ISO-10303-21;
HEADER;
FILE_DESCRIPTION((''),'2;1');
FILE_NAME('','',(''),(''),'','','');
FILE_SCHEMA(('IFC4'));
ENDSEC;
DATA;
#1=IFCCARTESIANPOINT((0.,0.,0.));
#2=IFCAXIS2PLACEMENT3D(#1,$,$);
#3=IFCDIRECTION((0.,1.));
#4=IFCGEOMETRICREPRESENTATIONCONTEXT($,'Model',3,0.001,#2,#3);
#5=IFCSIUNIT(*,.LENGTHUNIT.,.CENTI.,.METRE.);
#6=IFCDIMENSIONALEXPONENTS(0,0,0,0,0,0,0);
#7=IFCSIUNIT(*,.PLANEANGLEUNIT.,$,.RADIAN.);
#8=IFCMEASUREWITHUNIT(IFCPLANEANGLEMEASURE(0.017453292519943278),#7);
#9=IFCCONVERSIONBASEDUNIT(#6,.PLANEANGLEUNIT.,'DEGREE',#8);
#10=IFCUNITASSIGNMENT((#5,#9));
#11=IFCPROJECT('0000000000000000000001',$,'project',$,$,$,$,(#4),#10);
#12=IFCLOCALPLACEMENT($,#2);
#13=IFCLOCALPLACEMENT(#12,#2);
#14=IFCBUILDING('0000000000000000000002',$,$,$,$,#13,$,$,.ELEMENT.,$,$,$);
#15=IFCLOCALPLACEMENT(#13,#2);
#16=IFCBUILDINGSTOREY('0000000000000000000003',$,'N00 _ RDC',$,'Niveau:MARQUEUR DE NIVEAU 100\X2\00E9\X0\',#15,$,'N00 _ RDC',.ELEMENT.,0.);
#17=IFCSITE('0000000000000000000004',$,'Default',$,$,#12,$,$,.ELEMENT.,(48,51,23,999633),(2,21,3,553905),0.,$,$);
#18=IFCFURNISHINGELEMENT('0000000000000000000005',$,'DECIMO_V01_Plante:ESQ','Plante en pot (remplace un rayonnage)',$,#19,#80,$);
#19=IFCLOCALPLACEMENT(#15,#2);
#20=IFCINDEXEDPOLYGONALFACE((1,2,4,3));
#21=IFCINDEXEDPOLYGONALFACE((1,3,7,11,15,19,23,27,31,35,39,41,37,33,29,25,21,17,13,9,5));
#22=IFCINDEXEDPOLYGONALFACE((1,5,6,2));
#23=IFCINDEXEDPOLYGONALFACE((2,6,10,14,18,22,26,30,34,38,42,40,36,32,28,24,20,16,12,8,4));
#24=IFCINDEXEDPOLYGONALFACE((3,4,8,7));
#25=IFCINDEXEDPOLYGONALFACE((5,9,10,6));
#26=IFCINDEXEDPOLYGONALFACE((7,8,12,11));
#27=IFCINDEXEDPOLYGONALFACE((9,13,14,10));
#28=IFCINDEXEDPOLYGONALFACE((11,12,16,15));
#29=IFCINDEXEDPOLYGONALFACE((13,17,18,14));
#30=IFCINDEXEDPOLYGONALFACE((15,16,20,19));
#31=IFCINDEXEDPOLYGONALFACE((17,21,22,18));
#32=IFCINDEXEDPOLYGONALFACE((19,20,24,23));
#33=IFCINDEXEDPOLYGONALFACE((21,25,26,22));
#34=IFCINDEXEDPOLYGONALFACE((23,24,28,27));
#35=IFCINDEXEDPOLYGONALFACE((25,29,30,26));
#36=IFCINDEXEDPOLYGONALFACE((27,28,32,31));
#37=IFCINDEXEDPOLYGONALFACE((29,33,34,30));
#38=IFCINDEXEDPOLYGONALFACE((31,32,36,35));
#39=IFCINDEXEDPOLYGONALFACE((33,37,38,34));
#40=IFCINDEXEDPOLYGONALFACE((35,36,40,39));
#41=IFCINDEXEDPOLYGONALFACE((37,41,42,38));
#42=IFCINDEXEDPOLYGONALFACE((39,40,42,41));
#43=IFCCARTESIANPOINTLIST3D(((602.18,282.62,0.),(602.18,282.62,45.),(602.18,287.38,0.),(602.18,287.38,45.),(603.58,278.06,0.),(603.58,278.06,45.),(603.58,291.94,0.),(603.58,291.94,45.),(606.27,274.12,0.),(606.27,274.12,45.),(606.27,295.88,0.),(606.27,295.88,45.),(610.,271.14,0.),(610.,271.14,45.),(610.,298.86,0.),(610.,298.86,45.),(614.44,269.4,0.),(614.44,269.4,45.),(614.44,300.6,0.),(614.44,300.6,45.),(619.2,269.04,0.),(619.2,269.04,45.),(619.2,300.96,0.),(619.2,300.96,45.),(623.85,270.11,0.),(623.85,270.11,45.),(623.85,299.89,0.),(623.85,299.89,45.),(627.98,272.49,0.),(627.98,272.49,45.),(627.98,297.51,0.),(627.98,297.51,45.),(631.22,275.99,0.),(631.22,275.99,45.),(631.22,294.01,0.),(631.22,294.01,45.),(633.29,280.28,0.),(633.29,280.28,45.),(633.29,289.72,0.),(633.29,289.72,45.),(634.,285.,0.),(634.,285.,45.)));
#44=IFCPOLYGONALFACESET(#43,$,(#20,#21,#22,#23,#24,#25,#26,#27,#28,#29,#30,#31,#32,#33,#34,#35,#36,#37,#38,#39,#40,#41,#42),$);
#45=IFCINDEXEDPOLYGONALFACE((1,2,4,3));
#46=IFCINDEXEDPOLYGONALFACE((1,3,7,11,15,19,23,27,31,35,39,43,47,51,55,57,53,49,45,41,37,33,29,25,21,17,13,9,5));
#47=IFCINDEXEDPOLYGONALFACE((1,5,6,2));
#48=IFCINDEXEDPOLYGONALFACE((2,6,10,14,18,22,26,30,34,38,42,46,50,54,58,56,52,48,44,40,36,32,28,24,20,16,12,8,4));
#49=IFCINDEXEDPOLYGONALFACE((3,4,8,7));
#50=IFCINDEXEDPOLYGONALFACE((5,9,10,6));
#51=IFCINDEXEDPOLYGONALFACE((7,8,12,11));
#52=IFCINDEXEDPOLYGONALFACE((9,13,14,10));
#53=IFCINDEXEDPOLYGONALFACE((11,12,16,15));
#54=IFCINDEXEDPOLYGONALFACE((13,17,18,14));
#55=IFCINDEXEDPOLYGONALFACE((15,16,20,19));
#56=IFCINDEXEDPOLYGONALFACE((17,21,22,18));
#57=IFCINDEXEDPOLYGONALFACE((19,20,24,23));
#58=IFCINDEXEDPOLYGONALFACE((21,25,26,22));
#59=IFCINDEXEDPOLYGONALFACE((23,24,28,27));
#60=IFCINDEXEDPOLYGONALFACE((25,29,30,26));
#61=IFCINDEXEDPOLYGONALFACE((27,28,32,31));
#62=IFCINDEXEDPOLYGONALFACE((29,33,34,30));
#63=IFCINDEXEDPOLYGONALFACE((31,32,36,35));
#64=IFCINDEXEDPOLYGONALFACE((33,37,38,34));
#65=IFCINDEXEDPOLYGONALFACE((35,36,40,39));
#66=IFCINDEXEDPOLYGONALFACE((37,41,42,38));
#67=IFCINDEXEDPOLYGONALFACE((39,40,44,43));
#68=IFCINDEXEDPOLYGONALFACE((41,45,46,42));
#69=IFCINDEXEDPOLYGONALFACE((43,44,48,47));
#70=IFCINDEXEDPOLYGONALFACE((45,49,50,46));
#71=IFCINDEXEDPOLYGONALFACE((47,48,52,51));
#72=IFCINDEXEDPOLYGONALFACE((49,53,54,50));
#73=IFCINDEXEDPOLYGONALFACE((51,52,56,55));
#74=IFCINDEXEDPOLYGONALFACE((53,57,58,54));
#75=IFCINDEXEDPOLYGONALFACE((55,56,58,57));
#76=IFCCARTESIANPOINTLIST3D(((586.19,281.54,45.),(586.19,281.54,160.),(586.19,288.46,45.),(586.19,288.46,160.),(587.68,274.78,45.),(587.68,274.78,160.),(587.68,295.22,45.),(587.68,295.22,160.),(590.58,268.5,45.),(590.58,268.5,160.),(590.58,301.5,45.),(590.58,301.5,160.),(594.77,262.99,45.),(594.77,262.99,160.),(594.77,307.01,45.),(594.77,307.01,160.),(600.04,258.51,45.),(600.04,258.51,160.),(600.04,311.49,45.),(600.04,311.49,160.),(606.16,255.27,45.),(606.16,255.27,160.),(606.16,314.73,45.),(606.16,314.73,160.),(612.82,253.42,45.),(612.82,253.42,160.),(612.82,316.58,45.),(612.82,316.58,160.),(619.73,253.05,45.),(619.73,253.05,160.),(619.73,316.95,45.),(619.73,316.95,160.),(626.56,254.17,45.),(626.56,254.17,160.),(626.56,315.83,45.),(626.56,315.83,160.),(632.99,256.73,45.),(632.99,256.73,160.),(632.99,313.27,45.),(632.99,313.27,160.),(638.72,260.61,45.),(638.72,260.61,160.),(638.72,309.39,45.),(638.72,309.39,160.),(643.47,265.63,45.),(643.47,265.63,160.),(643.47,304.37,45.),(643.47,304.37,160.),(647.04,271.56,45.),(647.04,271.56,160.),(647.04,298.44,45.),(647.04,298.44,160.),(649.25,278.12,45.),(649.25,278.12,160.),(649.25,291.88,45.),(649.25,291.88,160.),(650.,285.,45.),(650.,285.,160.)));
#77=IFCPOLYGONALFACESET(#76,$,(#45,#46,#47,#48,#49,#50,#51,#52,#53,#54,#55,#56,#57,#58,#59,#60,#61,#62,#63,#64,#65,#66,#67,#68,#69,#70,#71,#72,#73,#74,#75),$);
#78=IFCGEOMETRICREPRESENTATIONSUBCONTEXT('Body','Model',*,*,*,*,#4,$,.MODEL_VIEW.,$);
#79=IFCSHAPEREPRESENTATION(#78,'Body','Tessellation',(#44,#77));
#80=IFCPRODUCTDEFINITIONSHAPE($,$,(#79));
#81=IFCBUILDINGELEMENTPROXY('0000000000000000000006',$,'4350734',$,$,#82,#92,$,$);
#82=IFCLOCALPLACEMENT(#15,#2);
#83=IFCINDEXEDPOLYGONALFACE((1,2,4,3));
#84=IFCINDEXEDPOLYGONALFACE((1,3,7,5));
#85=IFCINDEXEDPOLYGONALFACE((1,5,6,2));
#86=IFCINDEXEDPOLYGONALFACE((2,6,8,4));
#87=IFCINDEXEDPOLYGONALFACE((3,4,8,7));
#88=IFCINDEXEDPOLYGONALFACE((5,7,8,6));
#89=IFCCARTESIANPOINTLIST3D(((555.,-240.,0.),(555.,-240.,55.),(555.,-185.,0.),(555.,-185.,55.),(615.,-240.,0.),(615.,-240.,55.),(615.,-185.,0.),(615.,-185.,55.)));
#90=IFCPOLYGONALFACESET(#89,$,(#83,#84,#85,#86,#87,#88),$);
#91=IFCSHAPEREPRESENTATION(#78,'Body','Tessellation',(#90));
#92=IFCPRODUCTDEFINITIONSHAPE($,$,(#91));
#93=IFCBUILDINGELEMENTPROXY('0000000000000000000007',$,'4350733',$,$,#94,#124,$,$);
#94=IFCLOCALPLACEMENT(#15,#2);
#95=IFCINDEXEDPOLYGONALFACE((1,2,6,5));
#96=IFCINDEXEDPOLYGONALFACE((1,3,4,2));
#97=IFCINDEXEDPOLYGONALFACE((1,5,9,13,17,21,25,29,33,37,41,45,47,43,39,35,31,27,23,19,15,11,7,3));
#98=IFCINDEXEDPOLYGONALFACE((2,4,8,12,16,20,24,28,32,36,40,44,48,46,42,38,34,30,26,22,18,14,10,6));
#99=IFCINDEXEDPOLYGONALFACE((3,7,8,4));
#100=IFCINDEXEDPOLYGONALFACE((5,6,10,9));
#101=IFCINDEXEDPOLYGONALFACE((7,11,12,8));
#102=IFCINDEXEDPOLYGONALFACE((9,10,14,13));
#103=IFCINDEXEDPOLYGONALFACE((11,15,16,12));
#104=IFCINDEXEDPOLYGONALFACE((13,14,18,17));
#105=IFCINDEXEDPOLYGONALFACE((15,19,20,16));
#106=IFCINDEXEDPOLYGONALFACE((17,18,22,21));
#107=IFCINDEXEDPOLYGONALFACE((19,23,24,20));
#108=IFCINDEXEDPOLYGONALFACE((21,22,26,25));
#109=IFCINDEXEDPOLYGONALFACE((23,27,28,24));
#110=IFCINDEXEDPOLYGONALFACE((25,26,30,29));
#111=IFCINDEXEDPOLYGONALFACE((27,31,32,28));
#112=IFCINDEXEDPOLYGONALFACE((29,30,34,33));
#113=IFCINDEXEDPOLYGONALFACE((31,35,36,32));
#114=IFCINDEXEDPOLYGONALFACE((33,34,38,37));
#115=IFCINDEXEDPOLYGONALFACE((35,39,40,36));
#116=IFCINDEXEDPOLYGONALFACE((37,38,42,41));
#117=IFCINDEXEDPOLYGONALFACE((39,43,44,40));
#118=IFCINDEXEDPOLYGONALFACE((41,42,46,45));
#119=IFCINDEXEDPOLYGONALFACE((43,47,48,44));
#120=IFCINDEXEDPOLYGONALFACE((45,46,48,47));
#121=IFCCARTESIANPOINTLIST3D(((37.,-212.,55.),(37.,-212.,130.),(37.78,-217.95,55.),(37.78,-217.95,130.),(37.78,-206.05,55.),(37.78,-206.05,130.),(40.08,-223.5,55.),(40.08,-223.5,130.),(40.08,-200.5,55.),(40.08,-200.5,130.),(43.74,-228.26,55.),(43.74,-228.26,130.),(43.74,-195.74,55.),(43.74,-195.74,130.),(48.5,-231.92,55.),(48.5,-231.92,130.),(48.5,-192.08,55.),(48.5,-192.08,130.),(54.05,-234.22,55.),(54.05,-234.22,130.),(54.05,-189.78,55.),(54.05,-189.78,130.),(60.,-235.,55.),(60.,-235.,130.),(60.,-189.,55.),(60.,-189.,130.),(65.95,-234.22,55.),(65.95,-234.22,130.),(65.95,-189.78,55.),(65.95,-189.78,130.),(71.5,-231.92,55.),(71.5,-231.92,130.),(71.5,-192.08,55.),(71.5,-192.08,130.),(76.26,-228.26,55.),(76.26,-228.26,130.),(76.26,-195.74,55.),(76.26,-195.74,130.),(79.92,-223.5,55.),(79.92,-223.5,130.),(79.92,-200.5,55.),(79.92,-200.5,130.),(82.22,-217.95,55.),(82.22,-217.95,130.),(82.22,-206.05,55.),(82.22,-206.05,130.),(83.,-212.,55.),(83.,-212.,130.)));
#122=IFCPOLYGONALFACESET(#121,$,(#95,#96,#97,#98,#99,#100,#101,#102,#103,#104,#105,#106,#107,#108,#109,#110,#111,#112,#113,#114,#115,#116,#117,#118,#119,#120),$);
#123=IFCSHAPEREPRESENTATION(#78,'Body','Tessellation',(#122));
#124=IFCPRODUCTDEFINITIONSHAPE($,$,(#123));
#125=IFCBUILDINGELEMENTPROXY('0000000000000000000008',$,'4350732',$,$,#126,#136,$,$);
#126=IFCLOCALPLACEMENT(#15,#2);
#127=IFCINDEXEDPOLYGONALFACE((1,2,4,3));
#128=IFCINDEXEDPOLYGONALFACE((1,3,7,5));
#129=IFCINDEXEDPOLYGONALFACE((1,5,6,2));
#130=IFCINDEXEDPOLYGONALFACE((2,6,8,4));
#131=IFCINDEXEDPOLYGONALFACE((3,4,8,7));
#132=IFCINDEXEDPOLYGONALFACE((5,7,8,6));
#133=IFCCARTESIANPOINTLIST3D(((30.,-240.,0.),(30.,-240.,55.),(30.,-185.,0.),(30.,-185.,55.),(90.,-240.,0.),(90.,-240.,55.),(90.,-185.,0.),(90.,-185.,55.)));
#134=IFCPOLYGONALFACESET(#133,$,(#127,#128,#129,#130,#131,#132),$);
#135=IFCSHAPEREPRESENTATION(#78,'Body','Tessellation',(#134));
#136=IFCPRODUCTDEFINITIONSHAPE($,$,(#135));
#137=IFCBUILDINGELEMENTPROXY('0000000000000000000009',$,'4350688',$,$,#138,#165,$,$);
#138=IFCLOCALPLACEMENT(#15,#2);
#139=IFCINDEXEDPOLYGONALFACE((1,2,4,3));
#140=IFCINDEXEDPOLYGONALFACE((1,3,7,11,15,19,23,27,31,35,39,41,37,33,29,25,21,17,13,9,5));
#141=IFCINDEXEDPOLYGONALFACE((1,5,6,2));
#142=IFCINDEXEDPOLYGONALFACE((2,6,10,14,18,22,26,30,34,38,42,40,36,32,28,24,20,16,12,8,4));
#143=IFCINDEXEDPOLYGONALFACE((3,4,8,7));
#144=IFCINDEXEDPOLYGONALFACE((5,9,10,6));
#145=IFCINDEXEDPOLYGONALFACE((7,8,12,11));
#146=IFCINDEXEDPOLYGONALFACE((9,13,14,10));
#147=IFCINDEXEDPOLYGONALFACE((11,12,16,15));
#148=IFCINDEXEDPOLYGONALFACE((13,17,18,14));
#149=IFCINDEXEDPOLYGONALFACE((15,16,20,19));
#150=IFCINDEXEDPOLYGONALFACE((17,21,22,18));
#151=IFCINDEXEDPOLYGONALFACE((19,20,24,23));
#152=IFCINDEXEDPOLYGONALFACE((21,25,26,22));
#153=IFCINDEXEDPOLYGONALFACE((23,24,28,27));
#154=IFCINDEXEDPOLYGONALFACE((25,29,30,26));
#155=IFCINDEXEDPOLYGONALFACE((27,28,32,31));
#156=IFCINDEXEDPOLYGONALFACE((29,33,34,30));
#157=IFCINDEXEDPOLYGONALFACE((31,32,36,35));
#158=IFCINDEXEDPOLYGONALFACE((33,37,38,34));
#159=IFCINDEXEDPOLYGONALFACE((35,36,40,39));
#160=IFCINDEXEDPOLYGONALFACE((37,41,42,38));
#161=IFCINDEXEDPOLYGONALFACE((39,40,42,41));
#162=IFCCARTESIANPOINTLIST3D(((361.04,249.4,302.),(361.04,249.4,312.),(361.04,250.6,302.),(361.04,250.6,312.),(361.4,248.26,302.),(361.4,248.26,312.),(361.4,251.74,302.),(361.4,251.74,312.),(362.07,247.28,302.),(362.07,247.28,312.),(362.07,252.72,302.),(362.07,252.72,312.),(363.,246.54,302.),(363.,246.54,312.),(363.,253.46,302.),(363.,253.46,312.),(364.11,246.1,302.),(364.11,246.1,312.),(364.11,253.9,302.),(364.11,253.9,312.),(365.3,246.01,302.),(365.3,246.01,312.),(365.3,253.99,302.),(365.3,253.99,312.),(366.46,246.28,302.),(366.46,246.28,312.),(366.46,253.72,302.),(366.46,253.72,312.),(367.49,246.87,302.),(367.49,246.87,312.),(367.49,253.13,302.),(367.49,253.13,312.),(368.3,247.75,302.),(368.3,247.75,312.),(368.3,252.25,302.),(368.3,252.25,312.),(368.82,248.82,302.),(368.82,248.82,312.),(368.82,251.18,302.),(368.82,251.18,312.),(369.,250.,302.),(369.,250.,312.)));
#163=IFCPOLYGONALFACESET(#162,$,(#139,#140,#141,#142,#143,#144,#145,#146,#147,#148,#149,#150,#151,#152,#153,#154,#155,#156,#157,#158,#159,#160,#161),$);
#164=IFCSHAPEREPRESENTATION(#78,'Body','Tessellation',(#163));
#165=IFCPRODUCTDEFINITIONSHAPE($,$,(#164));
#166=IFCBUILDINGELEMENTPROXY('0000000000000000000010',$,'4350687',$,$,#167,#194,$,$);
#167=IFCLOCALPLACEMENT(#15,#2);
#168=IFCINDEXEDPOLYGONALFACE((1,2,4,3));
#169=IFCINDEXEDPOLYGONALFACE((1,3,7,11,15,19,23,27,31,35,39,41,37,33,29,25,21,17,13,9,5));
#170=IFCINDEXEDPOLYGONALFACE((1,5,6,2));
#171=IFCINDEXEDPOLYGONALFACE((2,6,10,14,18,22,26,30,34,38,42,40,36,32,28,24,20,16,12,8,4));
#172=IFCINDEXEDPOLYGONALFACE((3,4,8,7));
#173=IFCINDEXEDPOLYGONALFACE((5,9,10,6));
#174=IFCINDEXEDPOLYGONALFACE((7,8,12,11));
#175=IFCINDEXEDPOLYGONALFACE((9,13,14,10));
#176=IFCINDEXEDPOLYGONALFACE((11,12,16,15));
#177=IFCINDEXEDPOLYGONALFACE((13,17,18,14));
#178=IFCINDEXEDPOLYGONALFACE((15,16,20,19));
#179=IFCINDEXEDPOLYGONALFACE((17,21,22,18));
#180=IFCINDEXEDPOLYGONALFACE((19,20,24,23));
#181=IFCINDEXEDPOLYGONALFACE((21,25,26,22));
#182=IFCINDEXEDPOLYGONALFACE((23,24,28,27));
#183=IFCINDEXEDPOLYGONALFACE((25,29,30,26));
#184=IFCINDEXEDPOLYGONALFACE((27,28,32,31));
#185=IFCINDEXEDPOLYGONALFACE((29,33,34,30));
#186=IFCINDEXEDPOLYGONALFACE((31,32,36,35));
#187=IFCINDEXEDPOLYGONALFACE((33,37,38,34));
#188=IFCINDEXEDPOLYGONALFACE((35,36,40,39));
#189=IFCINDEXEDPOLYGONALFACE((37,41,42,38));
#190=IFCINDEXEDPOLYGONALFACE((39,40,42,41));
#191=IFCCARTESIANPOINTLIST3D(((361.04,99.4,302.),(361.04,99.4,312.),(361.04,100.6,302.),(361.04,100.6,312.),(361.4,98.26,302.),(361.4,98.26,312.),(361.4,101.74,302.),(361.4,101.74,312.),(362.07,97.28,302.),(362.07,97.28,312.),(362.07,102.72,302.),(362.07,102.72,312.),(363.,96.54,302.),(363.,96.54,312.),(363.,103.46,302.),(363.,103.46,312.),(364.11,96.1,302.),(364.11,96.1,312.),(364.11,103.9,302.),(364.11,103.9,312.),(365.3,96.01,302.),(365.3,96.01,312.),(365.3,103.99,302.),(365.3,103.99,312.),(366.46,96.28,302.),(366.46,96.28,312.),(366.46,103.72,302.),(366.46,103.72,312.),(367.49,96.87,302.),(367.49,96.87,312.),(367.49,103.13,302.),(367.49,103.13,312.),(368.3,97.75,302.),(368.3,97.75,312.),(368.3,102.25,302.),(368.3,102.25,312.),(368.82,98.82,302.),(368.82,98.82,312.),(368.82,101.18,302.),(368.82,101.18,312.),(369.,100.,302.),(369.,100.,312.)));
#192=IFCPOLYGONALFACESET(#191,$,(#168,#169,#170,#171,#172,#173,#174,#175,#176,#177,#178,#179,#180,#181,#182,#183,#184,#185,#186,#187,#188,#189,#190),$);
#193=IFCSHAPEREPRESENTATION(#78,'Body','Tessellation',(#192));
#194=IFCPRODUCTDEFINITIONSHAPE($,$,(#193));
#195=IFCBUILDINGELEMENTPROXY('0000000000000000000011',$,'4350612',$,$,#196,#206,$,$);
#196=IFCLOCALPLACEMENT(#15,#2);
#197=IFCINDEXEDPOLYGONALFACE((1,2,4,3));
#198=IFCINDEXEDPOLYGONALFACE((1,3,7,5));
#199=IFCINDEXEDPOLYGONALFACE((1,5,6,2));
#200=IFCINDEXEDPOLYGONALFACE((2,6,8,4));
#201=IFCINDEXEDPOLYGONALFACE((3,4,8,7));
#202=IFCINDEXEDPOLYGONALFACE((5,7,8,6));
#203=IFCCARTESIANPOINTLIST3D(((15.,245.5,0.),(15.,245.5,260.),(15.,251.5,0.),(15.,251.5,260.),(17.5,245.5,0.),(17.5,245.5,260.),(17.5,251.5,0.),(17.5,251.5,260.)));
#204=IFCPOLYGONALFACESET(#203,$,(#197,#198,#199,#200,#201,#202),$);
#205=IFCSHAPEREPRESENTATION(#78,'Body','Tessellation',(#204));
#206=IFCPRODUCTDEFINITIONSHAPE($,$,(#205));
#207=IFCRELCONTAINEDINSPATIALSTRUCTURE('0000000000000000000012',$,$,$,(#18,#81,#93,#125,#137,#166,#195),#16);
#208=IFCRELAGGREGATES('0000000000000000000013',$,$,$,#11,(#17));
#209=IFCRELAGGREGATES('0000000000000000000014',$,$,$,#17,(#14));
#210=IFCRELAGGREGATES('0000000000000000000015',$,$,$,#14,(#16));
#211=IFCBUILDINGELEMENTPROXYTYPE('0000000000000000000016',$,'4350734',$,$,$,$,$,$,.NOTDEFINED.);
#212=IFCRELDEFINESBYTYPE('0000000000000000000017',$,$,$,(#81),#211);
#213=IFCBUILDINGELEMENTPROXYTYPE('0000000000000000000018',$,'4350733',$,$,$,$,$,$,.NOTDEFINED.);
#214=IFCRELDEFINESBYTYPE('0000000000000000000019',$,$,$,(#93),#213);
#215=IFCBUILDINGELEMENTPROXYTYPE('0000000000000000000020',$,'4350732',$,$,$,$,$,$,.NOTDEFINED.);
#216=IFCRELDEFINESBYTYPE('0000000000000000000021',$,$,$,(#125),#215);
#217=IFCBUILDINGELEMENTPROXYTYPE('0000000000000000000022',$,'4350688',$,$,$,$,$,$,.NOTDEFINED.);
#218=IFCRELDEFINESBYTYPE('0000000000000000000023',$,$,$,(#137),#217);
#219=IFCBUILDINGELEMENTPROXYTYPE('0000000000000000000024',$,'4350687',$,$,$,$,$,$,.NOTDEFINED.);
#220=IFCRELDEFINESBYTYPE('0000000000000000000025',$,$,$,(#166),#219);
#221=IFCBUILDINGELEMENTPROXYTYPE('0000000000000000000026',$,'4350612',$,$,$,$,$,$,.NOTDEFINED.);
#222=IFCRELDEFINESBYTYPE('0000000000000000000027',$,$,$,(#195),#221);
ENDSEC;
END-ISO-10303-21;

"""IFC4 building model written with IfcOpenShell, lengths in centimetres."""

from ifc_helpers import new_model, entity, si_unit, converted_unit, direction, frame, frame_2d, origin, origin_with_axes, origin_2d_with_axis, place, context, subcontext, project, spatial, rectangle, circle, extrude, type_object, element, save


model = new_model("IFC4")

# Units and contexts
model_context = context("Model", 3, precision=0.001, world=origin(), true_north=direction((0.0, 1.0)))
body_context = subcontext(model_context, "Body", "Model", "MODEL_VIEW")
ifc_project = project(units=[si_unit("LENGTHUNIT", "METRE", prefix="CENTI"), converted_unit("PLANEANGLEUNIT", "DEGREE", entity("IfcPlaneAngleMeasure", 0.017453292519943278), si_unit("PLANEANGLEUNIT", "RADIAN"), dimensions=[0, 0, 0, 0, 0, 0, 0])], contexts=[model_context])

# Site, building, storey
site_placement = place(None, origin())
site = spatial("IfcSite", under=ifc_project, at=site_placement, Name="Default", CompositionType="ELEMENT", RefLatitude=(48, 51, 23, 999633), RefLongitude=(2, 21, 3, 553905), RefElevation=0.0)
building_placement = place(site_placement, origin())
building = spatial("IfcBuilding", under=site, at=building_placement, CompositionType="ELEMENT")
storey_placement = place(building_placement, origin())
storey = spatial("IfcBuildingStorey", under=building, at=storey_placement, Name="N00 _ RDC", ObjectType="Niveau:MARQUEUR DE NIVEAU 100é", LongName="N00 _ RDC", CompositionType="ELEMENT", Elevation=0.0)

# Furnishing element
furnishing_placement = place(storey_placement, origin_with_axes())
element("IfcFurnishingElement", 1, at=furnishing_placement, inside=storey, Name="DECIMO_V01_Plante:ESQ", Description="Plante en pot (remplace un rayonnage)", context=body_context, shape_type="SweptSolid", body=[
    extrude(circle(Radius=16.0, at=frame_2d((618.0, 285.0))), origin(), (0.0, 0.0, 1.0), 45.0),
    extrude(circle(Radius=32.0, at=frame_2d((618.0, 285.0))), frame((0.0, 0.0, 45.0)), (0.0, 0.0, 1.0), 115.0),
])

# Building element proxies
building_element_proxy_type_1 = type_object("IfcBuildingElementProxyType", Name="4350734", PredefinedType="NOTDEFINED")
proxy_1_placement = place(storey_placement, origin())
element("IfcBuildingElementProxy", 2, at=proxy_1_placement, inside=storey, type_object=building_element_proxy_type_1, Name="4350734", context=body_context, shape_type="SweptSolid", body=[
    extrude(rectangle(XDim=60.0, YDim=55.0, at=origin_2d_with_axis()), frame((585.0, -212.5, 0.0)), (0.0, 0.0, 1.0), 55.0),
])
building_element_proxy_type_2 = type_object("IfcBuildingElementProxyType", Name="4350733", PredefinedType="NOTDEFINED")
proxy_2_placement = place(storey_placement, origin())
element("IfcBuildingElementProxy", 3, at=proxy_2_placement, inside=storey, type_object=building_element_proxy_type_2, Name="4350733", context=body_context, shape_type="SweptSolid", body=[
    extrude(circle(Radius=23.0, at=origin_2d_with_axis()), frame((60.0, -212.0, 55.0)), (0.0, 0.0, 1.0), 75.0),
])
building_element_proxy_type_3 = type_object("IfcBuildingElementProxyType", Name="4350732", PredefinedType="NOTDEFINED")
proxy_3_placement = place(storey_placement, origin())
element("IfcBuildingElementProxy", 4, at=proxy_3_placement, inside=storey, type_object=building_element_proxy_type_3, Name="4350732", context=body_context, shape_type="SweptSolid", body=[
    extrude(rectangle(XDim=60.0, YDim=55.0, at=frame_2d((0.0, 0.0), x_axis=(1.0, 0.0))), frame((60.0, -212.5, 0.0)), (0.0, 0.0, 1.0), 55.0),
])
building_element_proxy_type_4 = type_object("IfcBuildingElementProxyType", Name="4350688", PredefinedType="NOTDEFINED")
proxy_4_placement = place(storey_placement, origin())
element("IfcBuildingElementProxy", 5, at=proxy_4_placement, inside=storey, type_object=building_element_proxy_type_4, Name="4350688", context=body_context, shape_type="SweptSolid", body=[
    extrude(circle(Radius=4.0, at=origin_2d_with_axis()), frame((365.0, 250.0, 302.0)), (0.0, 0.0, 1.0), 10.0),
])
building_element_proxy_type_5 = type_object("IfcBuildingElementProxyType", Name="4350687", PredefinedType="NOTDEFINED")
proxy_5_placement = place(storey_placement, origin())
element("IfcBuildingElementProxy", 6, at=proxy_5_placement, inside=storey, type_object=building_element_proxy_type_5, Name="4350687", context=body_context, shape_type="SweptSolid", body=[
    extrude(circle(Radius=4.0, at=origin_2d_with_axis()), frame((365.0, 100.0, 302.0)), (0.0, 0.0, 1.0), 10.0),
])
building_element_proxy_type_6 = type_object("IfcBuildingElementProxyType", Name="4350612", PredefinedType="NOTDEFINED")
proxy_6_placement = place(storey_placement, origin())
element("IfcBuildingElementProxy", 7, at=proxy_6_placement, inside=storey, type_object=building_element_proxy_type_6, Name="4350612", context=body_context, shape_type="SweptSolid", body=[
    extrude(rectangle(XDim=2.5, YDim=6.0, at=frame_2d((0.0, 0.0), x_axis=(1.0, 0.0))), frame((16.25, 248.5, 0.0)), (0.0, 0.0, 1.0), 260.0),
])

save(model, "model.ifc")
